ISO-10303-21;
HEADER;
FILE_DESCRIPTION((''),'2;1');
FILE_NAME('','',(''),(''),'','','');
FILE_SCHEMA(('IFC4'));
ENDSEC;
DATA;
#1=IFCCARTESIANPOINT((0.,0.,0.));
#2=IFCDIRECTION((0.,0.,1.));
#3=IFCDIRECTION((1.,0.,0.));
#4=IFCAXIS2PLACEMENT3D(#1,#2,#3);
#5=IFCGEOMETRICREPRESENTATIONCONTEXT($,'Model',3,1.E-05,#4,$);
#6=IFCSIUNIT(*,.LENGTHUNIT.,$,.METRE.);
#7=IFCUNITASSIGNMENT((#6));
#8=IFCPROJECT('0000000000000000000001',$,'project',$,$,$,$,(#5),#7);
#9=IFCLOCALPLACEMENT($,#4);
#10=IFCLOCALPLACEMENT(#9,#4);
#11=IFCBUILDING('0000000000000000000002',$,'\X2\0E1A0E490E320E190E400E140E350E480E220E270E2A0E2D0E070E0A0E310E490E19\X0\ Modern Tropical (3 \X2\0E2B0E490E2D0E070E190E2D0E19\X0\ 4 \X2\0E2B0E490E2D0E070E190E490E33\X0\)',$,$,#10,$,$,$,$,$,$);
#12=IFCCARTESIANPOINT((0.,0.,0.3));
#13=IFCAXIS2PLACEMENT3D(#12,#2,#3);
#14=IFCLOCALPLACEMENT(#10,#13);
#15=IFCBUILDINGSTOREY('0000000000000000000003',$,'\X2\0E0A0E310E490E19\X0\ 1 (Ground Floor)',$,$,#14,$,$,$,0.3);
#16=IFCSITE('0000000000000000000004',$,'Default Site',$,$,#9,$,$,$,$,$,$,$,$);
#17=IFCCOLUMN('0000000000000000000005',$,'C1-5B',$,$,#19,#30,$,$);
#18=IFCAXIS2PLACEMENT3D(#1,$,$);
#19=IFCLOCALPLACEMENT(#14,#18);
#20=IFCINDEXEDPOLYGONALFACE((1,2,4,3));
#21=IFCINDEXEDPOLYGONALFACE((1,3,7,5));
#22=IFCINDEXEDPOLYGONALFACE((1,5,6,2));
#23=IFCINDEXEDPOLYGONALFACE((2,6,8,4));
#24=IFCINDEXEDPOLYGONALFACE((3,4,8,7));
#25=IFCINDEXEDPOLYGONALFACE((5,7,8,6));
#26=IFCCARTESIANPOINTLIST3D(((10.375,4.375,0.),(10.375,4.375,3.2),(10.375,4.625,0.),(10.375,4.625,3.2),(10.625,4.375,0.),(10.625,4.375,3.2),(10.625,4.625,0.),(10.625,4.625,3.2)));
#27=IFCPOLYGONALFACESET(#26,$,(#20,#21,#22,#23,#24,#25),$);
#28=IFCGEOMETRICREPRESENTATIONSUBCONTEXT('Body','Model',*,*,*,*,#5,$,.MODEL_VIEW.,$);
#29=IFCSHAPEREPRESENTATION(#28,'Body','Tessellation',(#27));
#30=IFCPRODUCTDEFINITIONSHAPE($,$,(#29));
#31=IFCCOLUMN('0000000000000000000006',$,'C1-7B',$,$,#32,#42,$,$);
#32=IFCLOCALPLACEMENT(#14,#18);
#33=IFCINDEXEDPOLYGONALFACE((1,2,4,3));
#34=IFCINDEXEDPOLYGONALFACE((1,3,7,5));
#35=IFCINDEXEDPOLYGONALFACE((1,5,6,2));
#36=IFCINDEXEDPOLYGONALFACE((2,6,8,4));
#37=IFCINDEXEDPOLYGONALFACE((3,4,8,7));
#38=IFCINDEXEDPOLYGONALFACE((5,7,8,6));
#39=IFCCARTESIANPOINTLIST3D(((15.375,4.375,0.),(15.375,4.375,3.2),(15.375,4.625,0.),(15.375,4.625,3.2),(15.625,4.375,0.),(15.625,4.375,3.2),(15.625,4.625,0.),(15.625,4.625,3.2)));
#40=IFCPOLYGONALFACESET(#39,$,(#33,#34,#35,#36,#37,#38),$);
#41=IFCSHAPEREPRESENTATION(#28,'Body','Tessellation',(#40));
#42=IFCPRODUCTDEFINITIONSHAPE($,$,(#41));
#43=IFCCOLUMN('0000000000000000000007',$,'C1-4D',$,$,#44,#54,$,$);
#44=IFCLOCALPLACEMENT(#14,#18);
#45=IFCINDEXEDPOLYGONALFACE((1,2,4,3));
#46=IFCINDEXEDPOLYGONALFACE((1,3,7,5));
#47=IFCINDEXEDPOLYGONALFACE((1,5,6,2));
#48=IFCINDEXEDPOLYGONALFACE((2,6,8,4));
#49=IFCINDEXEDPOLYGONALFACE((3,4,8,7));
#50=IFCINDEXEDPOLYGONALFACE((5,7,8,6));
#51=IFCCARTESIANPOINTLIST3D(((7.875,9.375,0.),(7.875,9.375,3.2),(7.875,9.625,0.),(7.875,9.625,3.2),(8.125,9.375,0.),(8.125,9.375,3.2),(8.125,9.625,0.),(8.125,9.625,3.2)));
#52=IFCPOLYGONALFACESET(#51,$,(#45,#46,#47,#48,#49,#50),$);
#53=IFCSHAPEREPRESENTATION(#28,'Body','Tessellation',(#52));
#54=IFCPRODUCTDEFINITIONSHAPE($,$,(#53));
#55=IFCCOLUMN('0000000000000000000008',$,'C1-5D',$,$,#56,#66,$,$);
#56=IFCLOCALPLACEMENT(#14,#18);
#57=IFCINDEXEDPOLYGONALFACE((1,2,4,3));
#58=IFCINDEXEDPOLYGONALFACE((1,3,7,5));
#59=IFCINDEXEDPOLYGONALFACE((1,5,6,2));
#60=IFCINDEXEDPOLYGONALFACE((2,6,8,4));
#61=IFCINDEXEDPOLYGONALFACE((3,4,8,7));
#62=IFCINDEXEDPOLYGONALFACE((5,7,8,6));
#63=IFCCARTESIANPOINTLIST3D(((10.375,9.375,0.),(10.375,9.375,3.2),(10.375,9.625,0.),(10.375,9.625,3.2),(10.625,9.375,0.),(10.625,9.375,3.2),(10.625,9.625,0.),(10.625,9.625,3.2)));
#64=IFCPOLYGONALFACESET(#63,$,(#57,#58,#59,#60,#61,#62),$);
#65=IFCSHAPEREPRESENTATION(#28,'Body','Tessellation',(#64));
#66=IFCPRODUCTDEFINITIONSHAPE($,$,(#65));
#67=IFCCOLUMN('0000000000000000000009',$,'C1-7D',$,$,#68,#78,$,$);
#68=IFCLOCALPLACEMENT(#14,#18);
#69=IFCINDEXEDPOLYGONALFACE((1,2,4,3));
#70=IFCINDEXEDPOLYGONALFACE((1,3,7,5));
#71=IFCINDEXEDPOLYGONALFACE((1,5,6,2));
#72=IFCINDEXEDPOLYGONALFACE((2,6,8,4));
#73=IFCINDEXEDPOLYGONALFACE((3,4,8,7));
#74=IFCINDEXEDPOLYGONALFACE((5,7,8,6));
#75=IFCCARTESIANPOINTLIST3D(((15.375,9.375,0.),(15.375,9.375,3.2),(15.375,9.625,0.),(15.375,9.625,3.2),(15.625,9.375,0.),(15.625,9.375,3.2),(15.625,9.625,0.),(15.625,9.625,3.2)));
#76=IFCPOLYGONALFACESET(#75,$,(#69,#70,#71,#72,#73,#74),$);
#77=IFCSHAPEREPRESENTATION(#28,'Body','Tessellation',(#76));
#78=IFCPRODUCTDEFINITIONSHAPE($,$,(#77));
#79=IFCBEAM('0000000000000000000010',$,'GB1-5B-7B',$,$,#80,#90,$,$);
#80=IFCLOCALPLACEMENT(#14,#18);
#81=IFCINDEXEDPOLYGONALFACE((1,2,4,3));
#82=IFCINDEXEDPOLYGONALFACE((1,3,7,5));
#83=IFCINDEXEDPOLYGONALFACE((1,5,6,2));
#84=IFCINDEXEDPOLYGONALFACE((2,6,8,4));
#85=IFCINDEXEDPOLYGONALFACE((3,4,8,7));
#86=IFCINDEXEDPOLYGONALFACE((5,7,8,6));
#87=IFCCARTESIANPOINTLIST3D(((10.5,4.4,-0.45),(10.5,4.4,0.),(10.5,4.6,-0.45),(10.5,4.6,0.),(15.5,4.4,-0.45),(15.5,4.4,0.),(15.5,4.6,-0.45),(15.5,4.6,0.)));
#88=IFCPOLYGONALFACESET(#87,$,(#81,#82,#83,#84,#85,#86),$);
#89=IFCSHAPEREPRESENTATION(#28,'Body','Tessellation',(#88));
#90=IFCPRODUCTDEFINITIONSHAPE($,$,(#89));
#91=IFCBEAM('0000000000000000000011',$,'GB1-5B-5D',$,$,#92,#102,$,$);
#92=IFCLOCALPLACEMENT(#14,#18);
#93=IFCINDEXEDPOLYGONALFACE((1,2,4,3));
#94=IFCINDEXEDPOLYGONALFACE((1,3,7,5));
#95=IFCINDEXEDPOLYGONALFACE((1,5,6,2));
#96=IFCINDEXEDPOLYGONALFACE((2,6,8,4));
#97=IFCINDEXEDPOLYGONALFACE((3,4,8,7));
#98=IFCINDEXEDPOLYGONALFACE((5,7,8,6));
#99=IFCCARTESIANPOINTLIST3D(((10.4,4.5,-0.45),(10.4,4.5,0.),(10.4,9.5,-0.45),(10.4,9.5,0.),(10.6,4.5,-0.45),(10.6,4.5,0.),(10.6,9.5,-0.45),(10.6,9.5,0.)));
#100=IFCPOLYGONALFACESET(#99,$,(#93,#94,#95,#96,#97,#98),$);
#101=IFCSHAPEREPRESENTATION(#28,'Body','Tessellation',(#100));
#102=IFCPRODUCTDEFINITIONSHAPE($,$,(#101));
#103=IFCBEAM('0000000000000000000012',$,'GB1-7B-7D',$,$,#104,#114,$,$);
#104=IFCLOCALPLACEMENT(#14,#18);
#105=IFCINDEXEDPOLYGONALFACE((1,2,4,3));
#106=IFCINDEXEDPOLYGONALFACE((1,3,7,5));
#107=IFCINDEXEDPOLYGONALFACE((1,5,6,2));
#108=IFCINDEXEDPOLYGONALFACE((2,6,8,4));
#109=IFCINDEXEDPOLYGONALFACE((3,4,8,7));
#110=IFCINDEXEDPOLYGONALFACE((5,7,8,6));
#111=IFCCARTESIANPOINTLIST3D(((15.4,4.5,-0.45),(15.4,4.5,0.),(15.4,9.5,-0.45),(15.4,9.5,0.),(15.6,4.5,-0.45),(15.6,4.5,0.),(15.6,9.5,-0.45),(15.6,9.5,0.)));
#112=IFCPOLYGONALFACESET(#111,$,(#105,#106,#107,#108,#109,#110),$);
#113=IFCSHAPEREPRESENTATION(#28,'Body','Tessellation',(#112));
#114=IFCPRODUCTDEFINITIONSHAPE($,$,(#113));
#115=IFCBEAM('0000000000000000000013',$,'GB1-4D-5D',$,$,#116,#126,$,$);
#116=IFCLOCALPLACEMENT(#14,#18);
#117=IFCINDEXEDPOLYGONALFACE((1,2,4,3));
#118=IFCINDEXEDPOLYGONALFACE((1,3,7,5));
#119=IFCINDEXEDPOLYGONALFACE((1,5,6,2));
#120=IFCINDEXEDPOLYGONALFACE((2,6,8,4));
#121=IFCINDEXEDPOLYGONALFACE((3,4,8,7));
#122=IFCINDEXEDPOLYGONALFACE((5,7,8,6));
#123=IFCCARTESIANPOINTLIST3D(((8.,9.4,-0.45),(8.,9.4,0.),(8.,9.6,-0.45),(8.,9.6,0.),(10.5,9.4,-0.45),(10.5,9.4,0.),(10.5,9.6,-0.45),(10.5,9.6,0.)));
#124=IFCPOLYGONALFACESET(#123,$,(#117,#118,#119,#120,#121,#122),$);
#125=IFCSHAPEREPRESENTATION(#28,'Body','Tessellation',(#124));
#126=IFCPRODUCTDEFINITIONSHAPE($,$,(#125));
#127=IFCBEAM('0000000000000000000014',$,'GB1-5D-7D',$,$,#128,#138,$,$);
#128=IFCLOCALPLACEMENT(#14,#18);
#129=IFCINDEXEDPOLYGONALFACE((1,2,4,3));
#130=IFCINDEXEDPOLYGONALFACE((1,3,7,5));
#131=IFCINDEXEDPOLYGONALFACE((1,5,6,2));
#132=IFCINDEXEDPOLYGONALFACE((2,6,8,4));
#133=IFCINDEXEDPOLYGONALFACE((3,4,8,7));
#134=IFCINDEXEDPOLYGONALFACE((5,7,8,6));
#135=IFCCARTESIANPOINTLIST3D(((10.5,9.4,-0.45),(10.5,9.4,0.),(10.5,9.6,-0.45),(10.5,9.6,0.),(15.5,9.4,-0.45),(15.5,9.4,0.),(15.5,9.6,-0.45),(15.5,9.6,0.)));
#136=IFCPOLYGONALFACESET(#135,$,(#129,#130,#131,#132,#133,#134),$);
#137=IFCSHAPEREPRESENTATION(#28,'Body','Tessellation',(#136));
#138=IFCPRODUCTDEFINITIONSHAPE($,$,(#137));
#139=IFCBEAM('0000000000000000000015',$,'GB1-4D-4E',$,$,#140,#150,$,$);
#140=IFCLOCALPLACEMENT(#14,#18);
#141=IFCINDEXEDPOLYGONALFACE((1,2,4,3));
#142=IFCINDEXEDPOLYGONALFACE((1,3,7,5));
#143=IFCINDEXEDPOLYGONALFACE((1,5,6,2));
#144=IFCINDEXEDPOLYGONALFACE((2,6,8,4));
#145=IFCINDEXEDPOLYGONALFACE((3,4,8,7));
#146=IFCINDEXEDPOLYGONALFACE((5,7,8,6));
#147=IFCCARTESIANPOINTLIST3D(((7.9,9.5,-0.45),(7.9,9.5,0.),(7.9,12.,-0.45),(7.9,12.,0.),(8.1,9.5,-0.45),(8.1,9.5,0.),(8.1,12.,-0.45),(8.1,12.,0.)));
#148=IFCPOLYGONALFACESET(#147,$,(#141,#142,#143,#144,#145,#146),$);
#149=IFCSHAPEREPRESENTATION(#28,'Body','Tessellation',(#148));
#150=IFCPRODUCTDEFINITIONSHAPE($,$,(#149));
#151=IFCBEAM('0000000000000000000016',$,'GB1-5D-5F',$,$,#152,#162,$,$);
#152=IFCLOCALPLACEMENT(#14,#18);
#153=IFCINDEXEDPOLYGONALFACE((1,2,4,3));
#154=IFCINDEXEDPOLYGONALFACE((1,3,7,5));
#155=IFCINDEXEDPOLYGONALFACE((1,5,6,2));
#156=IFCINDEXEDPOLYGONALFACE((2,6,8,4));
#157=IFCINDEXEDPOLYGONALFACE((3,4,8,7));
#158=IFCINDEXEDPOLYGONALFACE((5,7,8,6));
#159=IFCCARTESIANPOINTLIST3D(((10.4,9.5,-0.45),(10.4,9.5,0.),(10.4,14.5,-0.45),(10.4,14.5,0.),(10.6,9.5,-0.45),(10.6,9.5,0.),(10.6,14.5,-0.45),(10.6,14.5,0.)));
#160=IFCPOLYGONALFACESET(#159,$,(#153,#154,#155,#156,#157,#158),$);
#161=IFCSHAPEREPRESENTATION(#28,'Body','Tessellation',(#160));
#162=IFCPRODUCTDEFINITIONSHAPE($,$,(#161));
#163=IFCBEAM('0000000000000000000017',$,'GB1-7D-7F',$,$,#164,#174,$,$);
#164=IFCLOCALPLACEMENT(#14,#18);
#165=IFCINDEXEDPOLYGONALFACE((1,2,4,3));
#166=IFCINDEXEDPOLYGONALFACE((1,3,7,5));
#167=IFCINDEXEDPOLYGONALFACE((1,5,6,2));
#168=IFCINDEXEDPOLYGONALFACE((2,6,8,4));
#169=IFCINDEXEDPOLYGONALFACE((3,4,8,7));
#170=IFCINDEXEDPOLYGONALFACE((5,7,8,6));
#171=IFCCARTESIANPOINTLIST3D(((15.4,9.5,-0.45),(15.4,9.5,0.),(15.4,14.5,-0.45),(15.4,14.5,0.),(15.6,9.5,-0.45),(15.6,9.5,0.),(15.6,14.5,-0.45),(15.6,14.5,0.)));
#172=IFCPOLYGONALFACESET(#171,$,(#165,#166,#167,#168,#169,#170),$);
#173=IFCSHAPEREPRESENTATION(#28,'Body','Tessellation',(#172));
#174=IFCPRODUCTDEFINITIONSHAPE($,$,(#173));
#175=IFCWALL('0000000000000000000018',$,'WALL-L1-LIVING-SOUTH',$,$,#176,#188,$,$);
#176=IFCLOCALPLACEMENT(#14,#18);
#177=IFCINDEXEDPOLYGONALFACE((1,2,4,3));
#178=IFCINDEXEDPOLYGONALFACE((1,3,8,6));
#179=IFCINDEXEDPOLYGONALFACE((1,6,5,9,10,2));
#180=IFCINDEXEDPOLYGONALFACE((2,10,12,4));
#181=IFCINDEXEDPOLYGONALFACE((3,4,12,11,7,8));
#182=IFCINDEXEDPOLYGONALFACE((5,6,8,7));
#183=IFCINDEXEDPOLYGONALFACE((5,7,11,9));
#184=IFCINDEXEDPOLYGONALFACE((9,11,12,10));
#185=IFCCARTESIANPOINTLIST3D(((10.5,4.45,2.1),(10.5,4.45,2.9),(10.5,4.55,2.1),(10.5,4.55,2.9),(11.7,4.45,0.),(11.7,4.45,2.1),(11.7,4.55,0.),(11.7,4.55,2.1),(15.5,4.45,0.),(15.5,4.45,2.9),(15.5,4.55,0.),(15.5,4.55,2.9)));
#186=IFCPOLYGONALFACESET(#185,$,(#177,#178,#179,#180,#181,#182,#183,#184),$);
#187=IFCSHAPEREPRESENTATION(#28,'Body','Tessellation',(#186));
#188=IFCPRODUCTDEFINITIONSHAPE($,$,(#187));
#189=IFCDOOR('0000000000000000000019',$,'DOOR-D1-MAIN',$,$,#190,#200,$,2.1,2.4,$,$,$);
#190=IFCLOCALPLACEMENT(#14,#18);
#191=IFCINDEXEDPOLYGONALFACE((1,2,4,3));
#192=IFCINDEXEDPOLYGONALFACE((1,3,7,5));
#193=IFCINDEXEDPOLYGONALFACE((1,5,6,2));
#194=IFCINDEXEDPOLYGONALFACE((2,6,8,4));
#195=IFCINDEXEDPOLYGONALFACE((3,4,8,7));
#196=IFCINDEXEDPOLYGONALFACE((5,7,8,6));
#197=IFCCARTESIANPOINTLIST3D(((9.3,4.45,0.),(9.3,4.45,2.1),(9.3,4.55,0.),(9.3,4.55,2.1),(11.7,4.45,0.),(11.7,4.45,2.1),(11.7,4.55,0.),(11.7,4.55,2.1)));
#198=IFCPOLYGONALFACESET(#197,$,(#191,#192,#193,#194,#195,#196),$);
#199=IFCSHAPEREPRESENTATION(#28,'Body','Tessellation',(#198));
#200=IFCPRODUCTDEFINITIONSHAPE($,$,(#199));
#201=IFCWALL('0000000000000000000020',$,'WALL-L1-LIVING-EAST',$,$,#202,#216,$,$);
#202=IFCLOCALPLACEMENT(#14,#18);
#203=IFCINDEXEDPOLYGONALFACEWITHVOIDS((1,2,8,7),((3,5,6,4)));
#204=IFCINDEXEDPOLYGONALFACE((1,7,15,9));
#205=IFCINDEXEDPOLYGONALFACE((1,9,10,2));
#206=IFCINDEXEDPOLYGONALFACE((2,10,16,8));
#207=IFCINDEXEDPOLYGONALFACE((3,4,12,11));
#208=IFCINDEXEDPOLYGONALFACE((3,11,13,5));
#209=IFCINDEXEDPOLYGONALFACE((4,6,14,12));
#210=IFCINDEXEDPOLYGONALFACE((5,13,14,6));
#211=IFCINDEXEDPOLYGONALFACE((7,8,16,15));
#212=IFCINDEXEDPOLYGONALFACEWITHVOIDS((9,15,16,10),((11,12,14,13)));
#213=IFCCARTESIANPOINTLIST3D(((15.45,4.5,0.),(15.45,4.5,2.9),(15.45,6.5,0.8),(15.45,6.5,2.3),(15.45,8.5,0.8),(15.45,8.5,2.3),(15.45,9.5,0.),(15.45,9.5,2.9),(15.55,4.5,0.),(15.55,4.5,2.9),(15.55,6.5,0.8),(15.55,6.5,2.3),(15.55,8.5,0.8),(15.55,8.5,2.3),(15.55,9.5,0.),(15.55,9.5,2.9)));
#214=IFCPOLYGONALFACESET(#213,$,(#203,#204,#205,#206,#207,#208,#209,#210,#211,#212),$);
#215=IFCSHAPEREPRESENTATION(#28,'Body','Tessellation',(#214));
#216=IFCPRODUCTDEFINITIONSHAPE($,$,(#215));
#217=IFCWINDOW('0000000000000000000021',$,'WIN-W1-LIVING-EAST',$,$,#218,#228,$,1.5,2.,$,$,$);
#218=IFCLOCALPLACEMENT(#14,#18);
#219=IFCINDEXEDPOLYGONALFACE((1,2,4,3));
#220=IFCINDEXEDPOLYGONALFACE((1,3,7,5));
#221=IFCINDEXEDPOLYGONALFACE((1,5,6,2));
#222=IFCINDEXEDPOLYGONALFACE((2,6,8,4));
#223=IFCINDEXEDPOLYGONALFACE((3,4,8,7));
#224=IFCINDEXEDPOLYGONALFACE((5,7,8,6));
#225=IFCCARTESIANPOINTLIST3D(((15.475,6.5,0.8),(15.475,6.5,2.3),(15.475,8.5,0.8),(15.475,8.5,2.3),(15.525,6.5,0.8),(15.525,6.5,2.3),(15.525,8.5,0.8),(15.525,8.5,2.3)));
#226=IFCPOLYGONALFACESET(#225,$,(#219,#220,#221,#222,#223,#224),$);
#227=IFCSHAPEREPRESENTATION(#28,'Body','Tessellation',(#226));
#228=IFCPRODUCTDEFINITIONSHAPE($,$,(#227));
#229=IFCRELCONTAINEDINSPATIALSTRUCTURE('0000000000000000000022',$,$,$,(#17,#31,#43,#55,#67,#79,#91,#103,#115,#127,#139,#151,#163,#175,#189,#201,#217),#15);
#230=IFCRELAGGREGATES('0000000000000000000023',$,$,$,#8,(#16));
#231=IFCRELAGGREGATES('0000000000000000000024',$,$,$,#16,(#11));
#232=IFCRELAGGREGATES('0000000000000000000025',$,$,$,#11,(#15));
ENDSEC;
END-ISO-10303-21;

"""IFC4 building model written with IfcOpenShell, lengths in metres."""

from ifc_helpers import new_model, si_unit, frame, origin_with_axes, origin_2d, place, context, subcontext, project, spatial, rectangle, extrude, element, fill, save


model = new_model("IFC4")

# Units and contexts
model_context = context("Model", 3, precision=1e-05, world=origin_with_axes())
body_context = subcontext(model_context, "Body", "Model", "MODEL_VIEW")
ifc_project = project(units=[si_unit("LENGTHUNIT", "METRE")], contexts=[model_context])

# Site, building, storey
site_placement = place(None, origin_with_axes())
site = spatial("IfcSite", under=ifc_project, at=site_placement, Name="Default Site")
building_placement = place(site_placement, origin_with_axes())
building = spatial("IfcBuilding", under=site, at=building_placement, Name="บ้านเดี่ยวสองชั้น Modern Tropical (3 ห้องนอน 4 ห้องน้ำ)")
storey_placement = place(building_placement, frame((0.0, 0.0, 0.3), z_axis=(0.0, 0.0, 1.0), x_axis=(1.0, 0.0, 0.0)))
storey = spatial("IfcBuildingStorey", under=building, at=storey_placement, Name="ชั้น 1 (Ground Floor)", Elevation=0.3)

# Columns
for number, where, z_axis, x_axis, name in (
    (1, (10.5, 4.5, 0.0), (0.0, 0.0, 1.0), (1.0, 0.0, 0.0), "C1-5B"),
    (2, (15.5, 4.5, 0.0), (0.0, 0.0, 1.0), (1.0, 0.0, 0.0), "C1-7B"),
    (3, (8.0, 9.5, 0.0), (0.0, 0.0, 1.0), (1.0, 0.0, 0.0), "C1-4D"),
    (4, (10.5, 9.5, 0.0), (0.0, 0.0, 1.0), (1.0, 0.0, 0.0), "C1-5D"),
    (5, (15.5, 9.5, 0.0), (0.0, 0.0, 1.0), (1.0, 0.0, 0.0), "C1-7D"),
):
    element("IfcColumn", number, at=place(storey_placement, frame(where, z_axis=z_axis, x_axis=x_axis)), inside=storey, Name=name, context=body_context, shape_type="SweptSolid", body=[
        extrude(rectangle(XDim=0.25, YDim=0.25, at=origin_2d()), origin_with_axes(), (0.0, 0.0, 1.0), 3.2),
    ])

# Beams
for number, where, z_axis, x_axis, name in (
    (6, (10.5, 4.5, -0.225), (1.0, 0.0, 0.0), (0.0, 1.0, 0.0), "GB1-5B-7B"),
    (7, (10.5, 4.5, -0.225), (0.0, 1.0, 0.0), (-1.0, 0.0, 0.0), "GB1-5B-5D"),
    (8, (15.5, 4.5, -0.225), (0.0, 1.0, 0.0), (-1.0, 0.0, 0.0), "GB1-7B-7D"),
):
    element("IfcBeam", number, at=place(storey_placement, frame(where, z_axis=z_axis, x_axis=x_axis)), inside=storey, Name=name, context=body_context, shape_type="SweptSolid", body=[
        extrude(rectangle(XDim=0.2, YDim=0.45, at=origin_2d()), origin_with_axes(), (0.0, 0.0, 1.0), 5.0),
    ])
beam_1_placement = place(storey_placement, frame((8.0, 9.5, -0.225), z_axis=(1.0, 0.0, 0.0), x_axis=(0.0, 1.0, 0.0)))
element("IfcBeam", 9, at=beam_1_placement, inside=storey, Name="GB1-4D-5D", context=body_context, shape_type="SweptSolid", body=[
    extrude(rectangle(XDim=0.2, YDim=0.45, at=origin_2d()), origin_with_axes(), (0.0, 0.0, 1.0), 2.5),
])
beam_2_placement = place(storey_placement, frame((10.5, 9.5, -0.225), z_axis=(1.0, 0.0, 0.0), x_axis=(0.0, 1.0, 0.0)))
element("IfcBeam", 10, at=beam_2_placement, inside=storey, Name="GB1-5D-7D", context=body_context, shape_type="SweptSolid", body=[
    extrude(rectangle(XDim=0.2, YDim=0.45, at=origin_2d()), origin_with_axes(), (0.0, 0.0, 1.0), 5.0),
])
beam_3_placement = place(storey_placement, frame((8.0, 9.5, -0.225), z_axis=(0.0, 1.0, 0.0), x_axis=(-1.0, 0.0, 0.0)))
element("IfcBeam", 11, at=beam_3_placement, inside=storey, Name="GB1-4D-4E", context=body_context, shape_type="SweptSolid", body=[
    extrude(rectangle(XDim=0.2, YDim=0.45, at=origin_2d()), origin_with_axes(), (0.0, 0.0, 1.0), 2.5),
])
for number, where, z_axis, x_axis, name in (
    (12, (10.5, 9.5, -0.225), (0.0, 1.0, 0.0), (-1.0, 0.0, 0.0), "GB1-5D-5F"),
    (13, (15.5, 9.5, -0.225), (0.0, 1.0, 0.0), (-1.0, 0.0, 0.0), "GB1-7D-7F"),
):
    element("IfcBeam", number, at=place(storey_placement, frame(where, z_axis=z_axis, x_axis=x_axis)), inside=storey, Name=name, context=body_context, shape_type="SweptSolid", body=[
        extrude(rectangle(XDim=0.2, YDim=0.45, at=origin_2d()), origin_with_axes(), (0.0, 0.0, 1.0), 5.0),
    ])

# Wall, opening, door
wall_1_placement = place(storey_placement, frame((13.0, 4.5, 0.0), z_axis=(0.0, 0.0, 1.0), x_axis=(1.0, 0.0, 0.0)))
wall_1 = element("IfcWall", 14, at=wall_1_placement, inside=storey, Name="WALL-L1-LIVING-SOUTH", context=body_context, shape_type="SweptSolid", body=[
    extrude(rectangle(XDim=5.0, YDim=0.1, at=origin_2d()), origin_with_axes(), (0.0, 0.0, 1.0), 2.9),
])
opening_1_placement = place(wall_1_placement, frame((-2.5, 0.0, 0.0), z_axis=(0.0, 0.0, 1.0), x_axis=(1.0, 0.0, 0.0)))
opening_1 = element("IfcOpeningElement", 15, at=opening_1_placement, cuts=wall_1, context=body_context, shape_type="SweptSolid", body=[
    extrude(rectangle(XDim=2.4, YDim=0.12, at=origin_2d()), origin_with_axes(), (0.0, 0.0, 1.0), 2.1),
])
door_placement = place(opening_1_placement, origin_with_axes())
door = element("IfcDoor", 16, at=door_placement, inside=storey, Name="DOOR-D1-MAIN", OverallHeight=2.1, OverallWidth=2.4, context=body_context, shape_type="SweptSolid", body=[
    extrude(rectangle(XDim=2.4, YDim=0.1, at=origin_2d()), origin_with_axes(), (0.0, 0.0, 1.0), 2.1),
])
fill(opening_1, door)

# Wall, opening, window
wall_2_placement = place(storey_placement, frame((15.5, 7.0, 0.0), z_axis=(0.0, 0.0, 1.0), x_axis=(0.0, 1.0, 0.0)))
wall_2 = element("IfcWall", 17, at=wall_2_placement, inside=storey, Name="WALL-L1-LIVING-EAST", context=body_context, shape_type="SweptSolid", body=[
    extrude(rectangle(XDim=5.0, YDim=0.1, at=origin_2d()), origin_with_axes(), (0.0, 0.0, 1.0), 2.9),
])
opening_2_placement = place(wall_2_placement, frame((0.5, 0.0, 0.8), z_axis=(0.0, 0.0, 1.0), x_axis=(1.0, 0.0, 0.0)))
opening_2 = element("IfcOpeningElement", 18, at=opening_2_placement, cuts=wall_2, context=body_context, shape_type="SweptSolid", body=[
    extrude(rectangle(XDim=2.0, YDim=0.12, at=origin_2d()), origin_with_axes(), (0.0, 0.0, 1.0), 1.5),
])
window_placement = place(opening_2_placement, origin_with_axes())
window = element("IfcWindow", 19, at=window_placement, inside=storey, Name="WIN-W1-LIVING-EAST", OverallHeight=1.5, OverallWidth=2.0, context=body_context, shape_type="SweptSolid", body=[
    extrude(rectangle(XDim=2.0, YDim=0.05, at=origin_2d()), origin_with_axes(), (0.0, 0.0, 1.0), 1.5),
])
fill(opening_2, window)

save(model, "model.ifc")
